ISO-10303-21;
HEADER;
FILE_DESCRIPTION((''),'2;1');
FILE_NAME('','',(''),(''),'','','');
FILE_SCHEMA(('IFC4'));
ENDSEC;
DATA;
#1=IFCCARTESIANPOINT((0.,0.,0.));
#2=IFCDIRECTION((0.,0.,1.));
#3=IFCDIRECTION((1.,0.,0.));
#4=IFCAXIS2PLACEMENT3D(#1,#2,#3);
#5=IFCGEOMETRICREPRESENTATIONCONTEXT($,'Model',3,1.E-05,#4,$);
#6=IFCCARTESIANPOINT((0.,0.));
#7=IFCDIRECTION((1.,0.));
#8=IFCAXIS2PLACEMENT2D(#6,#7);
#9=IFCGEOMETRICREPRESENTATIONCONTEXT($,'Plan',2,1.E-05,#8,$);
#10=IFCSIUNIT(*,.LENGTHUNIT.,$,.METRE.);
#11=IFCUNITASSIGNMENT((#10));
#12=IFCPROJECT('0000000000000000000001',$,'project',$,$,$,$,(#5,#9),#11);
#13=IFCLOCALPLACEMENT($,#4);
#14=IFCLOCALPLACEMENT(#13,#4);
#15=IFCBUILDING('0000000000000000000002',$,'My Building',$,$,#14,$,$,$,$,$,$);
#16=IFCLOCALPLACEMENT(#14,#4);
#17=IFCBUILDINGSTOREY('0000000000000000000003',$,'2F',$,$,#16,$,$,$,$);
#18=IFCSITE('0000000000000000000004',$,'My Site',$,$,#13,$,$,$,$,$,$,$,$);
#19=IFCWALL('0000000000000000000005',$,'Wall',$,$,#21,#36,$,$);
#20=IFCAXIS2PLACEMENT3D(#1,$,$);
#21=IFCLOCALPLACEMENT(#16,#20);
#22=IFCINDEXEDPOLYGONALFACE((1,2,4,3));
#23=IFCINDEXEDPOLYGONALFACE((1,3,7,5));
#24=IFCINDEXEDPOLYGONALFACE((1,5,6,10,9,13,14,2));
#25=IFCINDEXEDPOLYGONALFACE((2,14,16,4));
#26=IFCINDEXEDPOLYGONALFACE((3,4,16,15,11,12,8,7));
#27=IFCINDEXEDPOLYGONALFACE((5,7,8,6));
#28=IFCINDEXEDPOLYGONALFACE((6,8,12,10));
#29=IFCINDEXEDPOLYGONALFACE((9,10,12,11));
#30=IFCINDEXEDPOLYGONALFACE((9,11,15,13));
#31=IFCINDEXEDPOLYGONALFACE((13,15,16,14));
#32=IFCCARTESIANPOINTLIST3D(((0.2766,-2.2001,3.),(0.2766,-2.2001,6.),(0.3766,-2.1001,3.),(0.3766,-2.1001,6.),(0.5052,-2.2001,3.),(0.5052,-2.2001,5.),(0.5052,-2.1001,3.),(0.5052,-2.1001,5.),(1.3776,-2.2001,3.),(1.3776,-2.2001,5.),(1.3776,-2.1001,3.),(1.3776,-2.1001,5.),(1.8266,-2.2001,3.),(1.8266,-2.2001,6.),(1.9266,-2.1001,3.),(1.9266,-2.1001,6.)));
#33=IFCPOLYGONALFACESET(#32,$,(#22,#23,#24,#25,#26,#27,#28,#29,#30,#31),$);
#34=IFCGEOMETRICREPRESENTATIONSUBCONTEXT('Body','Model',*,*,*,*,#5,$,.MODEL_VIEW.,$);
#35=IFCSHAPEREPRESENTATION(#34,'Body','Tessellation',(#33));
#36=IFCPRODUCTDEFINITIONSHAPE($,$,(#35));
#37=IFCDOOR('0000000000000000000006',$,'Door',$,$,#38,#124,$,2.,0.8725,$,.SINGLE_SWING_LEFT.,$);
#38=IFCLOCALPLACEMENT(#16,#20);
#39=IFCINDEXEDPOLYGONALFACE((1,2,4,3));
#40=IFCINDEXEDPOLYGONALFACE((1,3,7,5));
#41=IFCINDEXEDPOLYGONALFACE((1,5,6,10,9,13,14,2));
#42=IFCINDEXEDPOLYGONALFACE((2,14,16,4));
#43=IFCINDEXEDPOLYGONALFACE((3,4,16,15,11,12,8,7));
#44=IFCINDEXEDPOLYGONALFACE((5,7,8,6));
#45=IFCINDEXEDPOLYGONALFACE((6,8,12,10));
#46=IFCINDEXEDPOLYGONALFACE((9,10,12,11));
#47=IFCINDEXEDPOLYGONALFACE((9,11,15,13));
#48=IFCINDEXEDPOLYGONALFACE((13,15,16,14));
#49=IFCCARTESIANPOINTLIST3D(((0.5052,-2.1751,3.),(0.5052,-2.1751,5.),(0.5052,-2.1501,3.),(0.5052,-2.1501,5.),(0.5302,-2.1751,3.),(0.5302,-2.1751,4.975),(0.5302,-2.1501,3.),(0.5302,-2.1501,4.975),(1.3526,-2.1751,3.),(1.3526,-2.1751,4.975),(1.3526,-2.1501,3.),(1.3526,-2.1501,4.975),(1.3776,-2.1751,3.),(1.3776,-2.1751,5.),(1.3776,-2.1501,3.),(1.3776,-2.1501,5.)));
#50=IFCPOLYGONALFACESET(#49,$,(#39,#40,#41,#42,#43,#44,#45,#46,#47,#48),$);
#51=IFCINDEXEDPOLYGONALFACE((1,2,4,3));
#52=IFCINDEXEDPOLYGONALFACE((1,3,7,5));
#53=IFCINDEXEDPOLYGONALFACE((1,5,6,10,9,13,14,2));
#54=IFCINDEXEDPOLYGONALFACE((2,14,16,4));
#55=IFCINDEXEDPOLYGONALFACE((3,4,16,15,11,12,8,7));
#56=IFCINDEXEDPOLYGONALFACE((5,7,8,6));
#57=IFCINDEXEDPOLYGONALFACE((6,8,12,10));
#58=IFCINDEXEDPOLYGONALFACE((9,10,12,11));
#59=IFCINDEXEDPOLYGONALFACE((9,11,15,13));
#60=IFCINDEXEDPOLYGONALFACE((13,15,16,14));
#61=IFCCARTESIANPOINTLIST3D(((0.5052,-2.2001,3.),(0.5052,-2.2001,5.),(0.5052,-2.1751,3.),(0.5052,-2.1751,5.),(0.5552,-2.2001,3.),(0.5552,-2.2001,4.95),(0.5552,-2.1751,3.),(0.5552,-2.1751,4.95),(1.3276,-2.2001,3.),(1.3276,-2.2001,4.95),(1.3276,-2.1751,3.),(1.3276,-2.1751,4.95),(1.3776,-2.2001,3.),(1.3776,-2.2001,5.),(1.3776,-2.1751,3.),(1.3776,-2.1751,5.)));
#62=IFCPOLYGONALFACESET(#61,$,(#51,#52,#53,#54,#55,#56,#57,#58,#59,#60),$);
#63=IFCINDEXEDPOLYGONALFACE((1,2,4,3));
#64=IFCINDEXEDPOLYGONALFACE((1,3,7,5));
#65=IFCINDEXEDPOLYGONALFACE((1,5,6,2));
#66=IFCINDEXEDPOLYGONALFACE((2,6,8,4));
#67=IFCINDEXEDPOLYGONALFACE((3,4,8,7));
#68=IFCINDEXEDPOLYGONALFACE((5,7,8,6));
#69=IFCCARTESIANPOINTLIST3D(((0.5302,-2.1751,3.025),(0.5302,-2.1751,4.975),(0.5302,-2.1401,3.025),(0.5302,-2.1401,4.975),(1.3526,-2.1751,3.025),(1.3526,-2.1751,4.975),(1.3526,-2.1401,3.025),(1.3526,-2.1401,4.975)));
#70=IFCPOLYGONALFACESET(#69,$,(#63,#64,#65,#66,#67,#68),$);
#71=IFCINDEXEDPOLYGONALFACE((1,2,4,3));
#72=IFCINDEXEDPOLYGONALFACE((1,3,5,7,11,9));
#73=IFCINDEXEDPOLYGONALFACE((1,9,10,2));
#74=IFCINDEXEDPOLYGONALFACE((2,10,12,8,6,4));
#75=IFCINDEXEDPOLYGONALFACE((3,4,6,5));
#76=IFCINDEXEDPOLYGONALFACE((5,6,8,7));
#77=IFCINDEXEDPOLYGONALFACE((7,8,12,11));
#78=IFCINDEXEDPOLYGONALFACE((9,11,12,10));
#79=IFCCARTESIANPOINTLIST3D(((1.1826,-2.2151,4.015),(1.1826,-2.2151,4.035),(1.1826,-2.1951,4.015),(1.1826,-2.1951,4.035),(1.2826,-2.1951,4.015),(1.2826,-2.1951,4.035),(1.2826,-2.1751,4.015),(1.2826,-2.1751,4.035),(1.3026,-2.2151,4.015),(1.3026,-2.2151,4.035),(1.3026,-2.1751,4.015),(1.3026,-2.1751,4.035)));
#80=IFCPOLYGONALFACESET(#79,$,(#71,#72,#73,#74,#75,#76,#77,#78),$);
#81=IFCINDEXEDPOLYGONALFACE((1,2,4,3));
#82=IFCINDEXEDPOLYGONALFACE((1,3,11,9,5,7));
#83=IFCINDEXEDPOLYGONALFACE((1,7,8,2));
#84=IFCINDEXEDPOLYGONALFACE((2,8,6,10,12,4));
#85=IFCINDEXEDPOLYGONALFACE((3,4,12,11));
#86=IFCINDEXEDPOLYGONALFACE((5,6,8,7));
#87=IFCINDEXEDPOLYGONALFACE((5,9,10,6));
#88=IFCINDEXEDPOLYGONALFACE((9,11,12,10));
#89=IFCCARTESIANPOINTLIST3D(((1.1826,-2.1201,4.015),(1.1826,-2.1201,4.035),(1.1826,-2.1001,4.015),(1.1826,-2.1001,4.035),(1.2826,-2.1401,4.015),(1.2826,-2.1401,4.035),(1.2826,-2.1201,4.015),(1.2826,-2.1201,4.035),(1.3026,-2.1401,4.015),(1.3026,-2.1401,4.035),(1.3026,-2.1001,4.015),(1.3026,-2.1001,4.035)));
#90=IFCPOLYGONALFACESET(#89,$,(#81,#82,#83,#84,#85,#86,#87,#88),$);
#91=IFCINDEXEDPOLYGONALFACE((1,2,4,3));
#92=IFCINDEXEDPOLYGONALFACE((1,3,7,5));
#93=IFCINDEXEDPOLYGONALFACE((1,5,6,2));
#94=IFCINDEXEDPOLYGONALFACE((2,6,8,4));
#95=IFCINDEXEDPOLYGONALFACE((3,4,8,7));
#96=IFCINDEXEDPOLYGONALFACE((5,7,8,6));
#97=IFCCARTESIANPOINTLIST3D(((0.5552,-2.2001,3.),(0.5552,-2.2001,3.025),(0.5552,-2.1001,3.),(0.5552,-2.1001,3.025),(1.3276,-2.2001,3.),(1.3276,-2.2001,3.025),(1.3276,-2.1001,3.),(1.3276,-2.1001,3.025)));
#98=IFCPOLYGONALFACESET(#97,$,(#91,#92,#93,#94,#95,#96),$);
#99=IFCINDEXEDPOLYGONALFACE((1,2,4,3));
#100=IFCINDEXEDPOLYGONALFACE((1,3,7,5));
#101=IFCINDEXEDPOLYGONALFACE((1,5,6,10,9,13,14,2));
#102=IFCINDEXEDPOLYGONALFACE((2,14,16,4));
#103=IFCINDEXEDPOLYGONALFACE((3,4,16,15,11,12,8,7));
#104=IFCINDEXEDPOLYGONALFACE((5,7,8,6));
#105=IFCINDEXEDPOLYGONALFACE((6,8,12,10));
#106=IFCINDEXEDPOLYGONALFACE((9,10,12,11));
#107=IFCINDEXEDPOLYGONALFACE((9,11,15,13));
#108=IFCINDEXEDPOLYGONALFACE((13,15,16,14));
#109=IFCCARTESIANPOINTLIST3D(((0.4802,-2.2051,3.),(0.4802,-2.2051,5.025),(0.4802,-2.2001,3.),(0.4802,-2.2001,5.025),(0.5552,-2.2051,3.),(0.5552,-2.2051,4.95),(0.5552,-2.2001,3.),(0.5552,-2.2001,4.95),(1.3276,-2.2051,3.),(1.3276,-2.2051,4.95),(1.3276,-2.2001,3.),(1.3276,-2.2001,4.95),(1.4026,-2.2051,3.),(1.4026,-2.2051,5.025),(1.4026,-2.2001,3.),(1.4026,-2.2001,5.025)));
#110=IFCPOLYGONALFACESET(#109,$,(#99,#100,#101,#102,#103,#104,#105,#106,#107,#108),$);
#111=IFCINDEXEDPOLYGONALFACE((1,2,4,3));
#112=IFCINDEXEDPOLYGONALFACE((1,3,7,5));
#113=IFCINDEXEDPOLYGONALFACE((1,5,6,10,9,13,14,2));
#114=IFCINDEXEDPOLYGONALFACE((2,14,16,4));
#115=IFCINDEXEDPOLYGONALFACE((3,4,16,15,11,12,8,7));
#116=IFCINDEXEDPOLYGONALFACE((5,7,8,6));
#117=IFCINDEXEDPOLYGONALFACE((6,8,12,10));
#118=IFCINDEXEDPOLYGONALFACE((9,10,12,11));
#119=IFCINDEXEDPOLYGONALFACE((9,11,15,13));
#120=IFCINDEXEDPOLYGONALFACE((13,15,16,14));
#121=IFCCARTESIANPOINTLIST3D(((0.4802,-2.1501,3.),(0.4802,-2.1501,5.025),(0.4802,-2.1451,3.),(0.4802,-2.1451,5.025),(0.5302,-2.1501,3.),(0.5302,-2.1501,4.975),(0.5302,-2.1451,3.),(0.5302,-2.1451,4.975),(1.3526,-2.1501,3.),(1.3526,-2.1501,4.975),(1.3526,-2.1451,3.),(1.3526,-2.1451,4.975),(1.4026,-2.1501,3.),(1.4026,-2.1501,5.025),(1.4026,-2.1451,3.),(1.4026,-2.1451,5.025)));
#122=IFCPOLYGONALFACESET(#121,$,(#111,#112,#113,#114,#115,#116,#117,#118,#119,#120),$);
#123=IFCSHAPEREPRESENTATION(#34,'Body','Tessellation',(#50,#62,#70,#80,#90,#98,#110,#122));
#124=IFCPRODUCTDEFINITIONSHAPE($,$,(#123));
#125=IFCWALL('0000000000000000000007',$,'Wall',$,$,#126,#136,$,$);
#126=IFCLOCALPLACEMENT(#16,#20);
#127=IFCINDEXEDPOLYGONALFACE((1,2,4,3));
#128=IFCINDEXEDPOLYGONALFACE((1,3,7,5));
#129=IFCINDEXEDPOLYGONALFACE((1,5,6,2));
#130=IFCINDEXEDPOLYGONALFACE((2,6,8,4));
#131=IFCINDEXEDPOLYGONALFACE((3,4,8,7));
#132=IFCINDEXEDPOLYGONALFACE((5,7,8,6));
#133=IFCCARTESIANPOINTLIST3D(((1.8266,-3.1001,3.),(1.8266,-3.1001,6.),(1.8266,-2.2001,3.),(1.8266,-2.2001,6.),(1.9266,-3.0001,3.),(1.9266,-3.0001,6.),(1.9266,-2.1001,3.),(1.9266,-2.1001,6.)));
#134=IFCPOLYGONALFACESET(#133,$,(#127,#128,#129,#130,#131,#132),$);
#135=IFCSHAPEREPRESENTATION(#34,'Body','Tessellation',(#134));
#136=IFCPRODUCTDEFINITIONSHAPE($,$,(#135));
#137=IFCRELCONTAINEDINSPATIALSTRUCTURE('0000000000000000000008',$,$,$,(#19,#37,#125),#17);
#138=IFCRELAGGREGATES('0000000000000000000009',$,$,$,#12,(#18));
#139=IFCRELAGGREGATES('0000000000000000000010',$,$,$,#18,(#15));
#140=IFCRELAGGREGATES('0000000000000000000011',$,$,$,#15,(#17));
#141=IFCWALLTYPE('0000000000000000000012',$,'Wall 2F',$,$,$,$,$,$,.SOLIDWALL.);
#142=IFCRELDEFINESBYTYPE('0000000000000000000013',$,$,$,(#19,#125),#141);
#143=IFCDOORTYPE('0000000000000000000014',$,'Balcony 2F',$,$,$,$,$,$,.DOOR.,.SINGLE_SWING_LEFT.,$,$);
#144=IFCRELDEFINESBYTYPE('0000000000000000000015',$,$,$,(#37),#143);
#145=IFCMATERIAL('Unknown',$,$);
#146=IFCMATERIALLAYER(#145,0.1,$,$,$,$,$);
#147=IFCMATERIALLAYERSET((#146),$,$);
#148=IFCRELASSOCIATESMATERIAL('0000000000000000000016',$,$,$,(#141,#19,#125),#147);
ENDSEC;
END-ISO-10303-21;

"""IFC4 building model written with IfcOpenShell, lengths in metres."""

from ifc_helpers import new_model, entity, si_unit, frame, origin_with_axes, origin_2d_with_axis, place, context, subcontext, project, spatial, line, indexed_curve, outline, extrude, shape, source, transform, mapped, material, layer, layer_set, layer_usage, type_object, type_shapes, element, fill, save


model = new_model("IFC4")

# Units and contexts
model_context = context("Model", 3, precision=1e-05, world=origin_with_axes())
plan_context = context("Plan", 2, precision=1e-05, world=origin_2d_with_axis())
body_context_1 = subcontext(model_context, "Body", "Model", "MODEL_VIEW")
body_context_2 = subcontext(plan_context, "Body", "Plan", "PLAN_VIEW")
ifc_project = project(units=[si_unit("LENGTHUNIT", "METRE")], contexts=[model_context, plan_context])

# Site, building, storey
site_placement = place(None, origin_with_axes())
site = spatial("IfcSite", under=ifc_project, at=site_placement, Name="My Site")
building_placement = place(site_placement, origin_with_axes())
building = spatial("IfcBuilding", under=site, at=building_placement, Name="My Building")
storey_placement = place(building_placement, origin_with_axes())
storey = spatial("IfcBuildingStorey", under=building, at=storey_placement, Name="2F")

# Shared definitions
ifc_material = material(Name="Unknown")

# Shared definitions
ifc_layer_1 = layer(ifc_material, 0.1)
ifc_layer_set_1 = layer_set([ifc_layer_1])
wall_type = type_object("IfcWallType", Name="Wall 2F", PredefinedType="SOLIDWALL", material=ifc_layer_set_1)

# Wall, opening, door
ifc_layer_usage_1 = layer_usage(ifc_layer_set_1, "AXIS2", "POSITIVE", 0.0)
wall_1_placement = place(storey_placement, frame((0.2766, -2.2001, 3.0), z_axis=(0.0, 0.0, 1.0), x_axis=(1.0, 0.0, 0.0)))
wall_1 = element("IfcWall", 1, at=wall_1_placement, inside=storey, type_object=wall_type, material=ifc_layer_usage_1, Name="Wall", context=body_context_1, shape_type="SweptSolid", body=[
    extrude(outline(indexed_curve([(0.0, 0.0), (0.1, 0.1), (1.65, 0.1), (1.55, 0.0)], segments=[line(1, 2, 3, 4, 1)])), origin_with_axes(), (0.0, 0.0, 1.0), 3.0),
])
shared_shape_1 = source(origin_with_axes(), body_context_1, "Body", "SweptSolid", [
    extrude(outline(indexed_curve([(0.0, 0.0), (0.8725, 0.0), (0.8725, 2.0), (0.0, 2.0)], segments=[line(1, 2, 3, 4, 1)])), frame((0.0, -0.6, 0.0), z_axis=(0.0, -1.0, 0.0), x_axis=(1.0, 0.0, 0.0)), (0.0, 0.0, -1.0), 1.2),
])
opening_1_placement = place(wall_1_placement, frame((0.2286, 0.0, 0.0), z_axis=(0.0, 0.0, 1.0), x_axis=(1.0, 0.0, 0.0)))
opening_1 = element("IfcOpeningElement", 2, at=opening_1_placement, cuts=wall_1, PredefinedType="OPENING", context=body_context_1, shape_type="MappedRepresentation", body=[
    mapped(shared_shape_1, transform((0.0, 0.0, 0.0), x_axis=(1.0, 0.0, 0.0), y_axis=(0.0, 1.0, 0.0), z_axis=(0.0, 0.0, 1.0), scale=1.0)),
])
door_type_1 = type_object("IfcDoorType", Name="Balcony 2F", OperationType="SINGLE_SWING_LEFT", PredefinedType="DOOR")
shared_shape_2 = source(origin_with_axes(), body_context_1, "Body", "SweptSolid", [
    extrude(outline(indexed_curve([(0.0, 0.0), (0.0, 2.0), (0.8725, 2.0), (0.8725, 0.0), (0.8475, 0.0), (0.8475, 1.975), (0.025, 1.975), (0.025, 0.0)], segments=[line(1, 2, 3, 4, 5, 6, 7, 8, 1)])), frame((0.0, 0.025, 0.0), z_axis=(0.0, -1.0, 0.0), x_axis=(1.0, 0.0, 0.0)), (0.0, 0.0, -1.0), 0.025),
    extrude(outline(indexed_curve([(0.0, 0.0), (0.0, 2.0), (0.8725, 2.0), (0.8725, 0.0), (0.8225, 0.0), (0.8225, 1.95), (0.05, 1.95), (0.05, 0.0)], segments=[line(1, 2, 3, 4, 5, 6, 7, 8, 1)])), frame((0.0, 0.0, 0.0), z_axis=(0.0, -1.0, 0.0), x_axis=(1.0, 0.0, 0.0)), (0.0, 0.0, -1.0), 0.025),
    extrude(outline(indexed_curve([(0.0, 0.0), (0.8225, 0.0), (0.8225, 0.035), (0.0, 0.035)], segments=[line(1, 2, 3, 4, 1)])), frame((0.025, 0.025, 0.025), z_axis=(0.0, 0.0, 1.0), x_axis=(1.0, 0.0, 0.0)), (0.0, 0.0, 1.0), 1.95),
    extrude(outline(indexed_curve([(0.0, 0.0), (0.0, -0.04), (-0.12, -0.04), (-0.12, -0.02), (-0.02, -0.02), (-0.02, 0.0)], segments=[line(1, 2, 3, 4, 5, 6, 1)])), frame((0.7975, 0.025, 1.015), z_axis=(0.0, 0.0, 1.0), x_axis=(1.0, 0.0, 0.0)), (0.0, 0.0, 1.0), 0.02),
    extrude(outline(indexed_curve([(0.0, 0.0), (0.0, 0.04), (-0.12, 0.04), (-0.12, 0.02), (-0.02, 0.02), (-0.02, 0.0)], segments=[line(1, 2, 3, 4, 5, 6, 1)])), frame((0.7975, 0.06, 1.015), z_axis=(0.0, 0.0, 1.0), x_axis=(1.0, 0.0, 0.0)), (0.0, 0.0, 1.0), 0.02),
    extrude(outline(indexed_curve([(0.0, 0.0), (0.7725, 0.0), (0.7725, 0.1), (0.0, 0.1)], segments=[line(1, 2, 3, 4, 1)])), frame((0.05, 0.0, 0.0), z_axis=(0.0, 0.0, 1.0), x_axis=(1.0, 0.0, 0.0)), (0.0, 0.0, 1.0), 0.025),
    extrude(outline(indexed_curve([(0.0, 0.0), (0.0, 2.025), (0.9225, 2.025), (0.9225, 0.0), (0.8475, 0.0), (0.8475, 1.95), (0.075, 1.95), (0.075, 0.0)], segments=[line(1, 2, 3, 4, 5, 6, 7, 8, 1)])), frame((-0.025, -0.005, 0.0), z_axis=(0.0, -1.0, 0.0), x_axis=(1.0, 0.0, 0.0)), (0.0, 0.0, -1.0), 0.005),
    extrude(outline(indexed_curve([(0.0, 0.0), (0.0, 2.025), (0.9225, 2.025), (0.9225, 0.0), (0.8725, 0.0), (0.8725, 1.975), (0.05, 1.975), (0.05, 0.0)], segments=[line(1, 2, 3, 4, 5, 6, 7, 8, 1)])), frame((-0.025, 0.05, 0.0), z_axis=(0.0, -1.0, 0.0), x_axis=(1.0, 0.0, 0.0)), (0.0, 0.0, -1.0), 0.005),
])
shared_shape_3 = source(origin_with_axes(), body_context_2, "Body", "Curve2D", [
    entity("IfcIndexedPolyCurve", entity("IfcCartesianPointList2D", [[0.0, 0.0], [0.0, 0.05], [0.025, 0.05], [0.025, 0.025], [0.05, 0.025], [0.05, 0.0]]), [entity("IfcLineIndex", [1, 2, 3, 4, 5, 6, 1])]),
    entity("IfcIndexedPolyCurve", entity("IfcCartesianPointList2D", [[0.8725, 0.0], [0.8725, 0.05], [0.8475, 0.05], [0.8475, 0.025], [0.8225, 0.025], [0.8225, 0.0]]), [entity("IfcLineIndex", [1, 2, 3, 4, 5, 6, 1])]),
    entity("IfcTrimmedCurve", entity("IfcEllipse", entity("IfcAxis2Placement2D", entity("IfcCartesianPoint", [0.06, 0.05]), entity("IfcDirection", [1.0, 0.0])), 0.7875, 0.8225), [entity("IfcCartesianPoint", [0.8475, 0.05])], [entity("IfcCartesianPoint", [0.06, 0.8725])], True, "CARTESIAN"),
    entity("IfcIndexedPolyCurve", entity("IfcCartesianPointList2D", [[0.025, 0.05], [0.06, 0.05], [0.06, 0.8725], [0.025, 0.8725]]), [entity("IfcLineIndex", [1, 2, 3, 4, 1])]),
])
type_shapes(door_type_1, [shared_shape_2, shared_shape_3])
door_1_placement = place(opening_1_placement, frame((0.0, 0.0, 0.0), z_axis=(0.0, 0.0, 1.0), x_axis=(1.0, 0.0, 0.0)))
door_1 = element("IfcDoor", 3, at=door_1_placement, inside=storey, type_object=door_type_1, Name="Door", OperationType="SINGLE_SWING_LEFT", OverallHeight=2.0, OverallWidth=0.8725, shapes=[
    shape(body_context_1, "Body", "MappedRepresentation", [mapped(shared_shape_2, transform((0.0, 0.0, 0.0), x_axis=(1.0, 0.0, 0.0), y_axis=(0.0, 1.0, 0.0), z_axis=(0.0, 0.0, 1.0), scale=1.0))]),
    shape(body_context_2, "Body", "MappedRepresentation", [mapped(shared_shape_3, transform((0.0, 0.0, 0.0), x_axis=(1.0, 0.0, 0.0), y_axis=(0.0, 1.0, 0.0), z_axis=(0.0, 0.0, 1.0), scale=1.0))]),
])
fill(opening_1, door_1)

# Wall
ifc_layer_usage_2 = layer_usage(ifc_layer_set_1, "AXIS2", "POSITIVE", 0.0)
wall_2_placement = place(storey_placement, frame((1.8266, -2.2001, 3.0), z_axis=(0.0, 0.0, 1.0), x_axis=(0.0, -1.0, 0.0)))
element("IfcWall", 4, at=wall_2_placement, inside=storey, type_object=wall_type, material=ifc_layer_usage_2, Name="Wall", context=body_context_1, shape_type="SweptSolid", body=[
    extrude(outline(indexed_curve([(0.0, 0.0), (-0.1, 0.1), (0.8, 0.1), (0.9, 0.0)], segments=[line(1, 2, 3, 4, 1)])), origin_with_axes(), (0.0, 0.0, 1.0), 3.0),
])

save(model, "model.ifc")
